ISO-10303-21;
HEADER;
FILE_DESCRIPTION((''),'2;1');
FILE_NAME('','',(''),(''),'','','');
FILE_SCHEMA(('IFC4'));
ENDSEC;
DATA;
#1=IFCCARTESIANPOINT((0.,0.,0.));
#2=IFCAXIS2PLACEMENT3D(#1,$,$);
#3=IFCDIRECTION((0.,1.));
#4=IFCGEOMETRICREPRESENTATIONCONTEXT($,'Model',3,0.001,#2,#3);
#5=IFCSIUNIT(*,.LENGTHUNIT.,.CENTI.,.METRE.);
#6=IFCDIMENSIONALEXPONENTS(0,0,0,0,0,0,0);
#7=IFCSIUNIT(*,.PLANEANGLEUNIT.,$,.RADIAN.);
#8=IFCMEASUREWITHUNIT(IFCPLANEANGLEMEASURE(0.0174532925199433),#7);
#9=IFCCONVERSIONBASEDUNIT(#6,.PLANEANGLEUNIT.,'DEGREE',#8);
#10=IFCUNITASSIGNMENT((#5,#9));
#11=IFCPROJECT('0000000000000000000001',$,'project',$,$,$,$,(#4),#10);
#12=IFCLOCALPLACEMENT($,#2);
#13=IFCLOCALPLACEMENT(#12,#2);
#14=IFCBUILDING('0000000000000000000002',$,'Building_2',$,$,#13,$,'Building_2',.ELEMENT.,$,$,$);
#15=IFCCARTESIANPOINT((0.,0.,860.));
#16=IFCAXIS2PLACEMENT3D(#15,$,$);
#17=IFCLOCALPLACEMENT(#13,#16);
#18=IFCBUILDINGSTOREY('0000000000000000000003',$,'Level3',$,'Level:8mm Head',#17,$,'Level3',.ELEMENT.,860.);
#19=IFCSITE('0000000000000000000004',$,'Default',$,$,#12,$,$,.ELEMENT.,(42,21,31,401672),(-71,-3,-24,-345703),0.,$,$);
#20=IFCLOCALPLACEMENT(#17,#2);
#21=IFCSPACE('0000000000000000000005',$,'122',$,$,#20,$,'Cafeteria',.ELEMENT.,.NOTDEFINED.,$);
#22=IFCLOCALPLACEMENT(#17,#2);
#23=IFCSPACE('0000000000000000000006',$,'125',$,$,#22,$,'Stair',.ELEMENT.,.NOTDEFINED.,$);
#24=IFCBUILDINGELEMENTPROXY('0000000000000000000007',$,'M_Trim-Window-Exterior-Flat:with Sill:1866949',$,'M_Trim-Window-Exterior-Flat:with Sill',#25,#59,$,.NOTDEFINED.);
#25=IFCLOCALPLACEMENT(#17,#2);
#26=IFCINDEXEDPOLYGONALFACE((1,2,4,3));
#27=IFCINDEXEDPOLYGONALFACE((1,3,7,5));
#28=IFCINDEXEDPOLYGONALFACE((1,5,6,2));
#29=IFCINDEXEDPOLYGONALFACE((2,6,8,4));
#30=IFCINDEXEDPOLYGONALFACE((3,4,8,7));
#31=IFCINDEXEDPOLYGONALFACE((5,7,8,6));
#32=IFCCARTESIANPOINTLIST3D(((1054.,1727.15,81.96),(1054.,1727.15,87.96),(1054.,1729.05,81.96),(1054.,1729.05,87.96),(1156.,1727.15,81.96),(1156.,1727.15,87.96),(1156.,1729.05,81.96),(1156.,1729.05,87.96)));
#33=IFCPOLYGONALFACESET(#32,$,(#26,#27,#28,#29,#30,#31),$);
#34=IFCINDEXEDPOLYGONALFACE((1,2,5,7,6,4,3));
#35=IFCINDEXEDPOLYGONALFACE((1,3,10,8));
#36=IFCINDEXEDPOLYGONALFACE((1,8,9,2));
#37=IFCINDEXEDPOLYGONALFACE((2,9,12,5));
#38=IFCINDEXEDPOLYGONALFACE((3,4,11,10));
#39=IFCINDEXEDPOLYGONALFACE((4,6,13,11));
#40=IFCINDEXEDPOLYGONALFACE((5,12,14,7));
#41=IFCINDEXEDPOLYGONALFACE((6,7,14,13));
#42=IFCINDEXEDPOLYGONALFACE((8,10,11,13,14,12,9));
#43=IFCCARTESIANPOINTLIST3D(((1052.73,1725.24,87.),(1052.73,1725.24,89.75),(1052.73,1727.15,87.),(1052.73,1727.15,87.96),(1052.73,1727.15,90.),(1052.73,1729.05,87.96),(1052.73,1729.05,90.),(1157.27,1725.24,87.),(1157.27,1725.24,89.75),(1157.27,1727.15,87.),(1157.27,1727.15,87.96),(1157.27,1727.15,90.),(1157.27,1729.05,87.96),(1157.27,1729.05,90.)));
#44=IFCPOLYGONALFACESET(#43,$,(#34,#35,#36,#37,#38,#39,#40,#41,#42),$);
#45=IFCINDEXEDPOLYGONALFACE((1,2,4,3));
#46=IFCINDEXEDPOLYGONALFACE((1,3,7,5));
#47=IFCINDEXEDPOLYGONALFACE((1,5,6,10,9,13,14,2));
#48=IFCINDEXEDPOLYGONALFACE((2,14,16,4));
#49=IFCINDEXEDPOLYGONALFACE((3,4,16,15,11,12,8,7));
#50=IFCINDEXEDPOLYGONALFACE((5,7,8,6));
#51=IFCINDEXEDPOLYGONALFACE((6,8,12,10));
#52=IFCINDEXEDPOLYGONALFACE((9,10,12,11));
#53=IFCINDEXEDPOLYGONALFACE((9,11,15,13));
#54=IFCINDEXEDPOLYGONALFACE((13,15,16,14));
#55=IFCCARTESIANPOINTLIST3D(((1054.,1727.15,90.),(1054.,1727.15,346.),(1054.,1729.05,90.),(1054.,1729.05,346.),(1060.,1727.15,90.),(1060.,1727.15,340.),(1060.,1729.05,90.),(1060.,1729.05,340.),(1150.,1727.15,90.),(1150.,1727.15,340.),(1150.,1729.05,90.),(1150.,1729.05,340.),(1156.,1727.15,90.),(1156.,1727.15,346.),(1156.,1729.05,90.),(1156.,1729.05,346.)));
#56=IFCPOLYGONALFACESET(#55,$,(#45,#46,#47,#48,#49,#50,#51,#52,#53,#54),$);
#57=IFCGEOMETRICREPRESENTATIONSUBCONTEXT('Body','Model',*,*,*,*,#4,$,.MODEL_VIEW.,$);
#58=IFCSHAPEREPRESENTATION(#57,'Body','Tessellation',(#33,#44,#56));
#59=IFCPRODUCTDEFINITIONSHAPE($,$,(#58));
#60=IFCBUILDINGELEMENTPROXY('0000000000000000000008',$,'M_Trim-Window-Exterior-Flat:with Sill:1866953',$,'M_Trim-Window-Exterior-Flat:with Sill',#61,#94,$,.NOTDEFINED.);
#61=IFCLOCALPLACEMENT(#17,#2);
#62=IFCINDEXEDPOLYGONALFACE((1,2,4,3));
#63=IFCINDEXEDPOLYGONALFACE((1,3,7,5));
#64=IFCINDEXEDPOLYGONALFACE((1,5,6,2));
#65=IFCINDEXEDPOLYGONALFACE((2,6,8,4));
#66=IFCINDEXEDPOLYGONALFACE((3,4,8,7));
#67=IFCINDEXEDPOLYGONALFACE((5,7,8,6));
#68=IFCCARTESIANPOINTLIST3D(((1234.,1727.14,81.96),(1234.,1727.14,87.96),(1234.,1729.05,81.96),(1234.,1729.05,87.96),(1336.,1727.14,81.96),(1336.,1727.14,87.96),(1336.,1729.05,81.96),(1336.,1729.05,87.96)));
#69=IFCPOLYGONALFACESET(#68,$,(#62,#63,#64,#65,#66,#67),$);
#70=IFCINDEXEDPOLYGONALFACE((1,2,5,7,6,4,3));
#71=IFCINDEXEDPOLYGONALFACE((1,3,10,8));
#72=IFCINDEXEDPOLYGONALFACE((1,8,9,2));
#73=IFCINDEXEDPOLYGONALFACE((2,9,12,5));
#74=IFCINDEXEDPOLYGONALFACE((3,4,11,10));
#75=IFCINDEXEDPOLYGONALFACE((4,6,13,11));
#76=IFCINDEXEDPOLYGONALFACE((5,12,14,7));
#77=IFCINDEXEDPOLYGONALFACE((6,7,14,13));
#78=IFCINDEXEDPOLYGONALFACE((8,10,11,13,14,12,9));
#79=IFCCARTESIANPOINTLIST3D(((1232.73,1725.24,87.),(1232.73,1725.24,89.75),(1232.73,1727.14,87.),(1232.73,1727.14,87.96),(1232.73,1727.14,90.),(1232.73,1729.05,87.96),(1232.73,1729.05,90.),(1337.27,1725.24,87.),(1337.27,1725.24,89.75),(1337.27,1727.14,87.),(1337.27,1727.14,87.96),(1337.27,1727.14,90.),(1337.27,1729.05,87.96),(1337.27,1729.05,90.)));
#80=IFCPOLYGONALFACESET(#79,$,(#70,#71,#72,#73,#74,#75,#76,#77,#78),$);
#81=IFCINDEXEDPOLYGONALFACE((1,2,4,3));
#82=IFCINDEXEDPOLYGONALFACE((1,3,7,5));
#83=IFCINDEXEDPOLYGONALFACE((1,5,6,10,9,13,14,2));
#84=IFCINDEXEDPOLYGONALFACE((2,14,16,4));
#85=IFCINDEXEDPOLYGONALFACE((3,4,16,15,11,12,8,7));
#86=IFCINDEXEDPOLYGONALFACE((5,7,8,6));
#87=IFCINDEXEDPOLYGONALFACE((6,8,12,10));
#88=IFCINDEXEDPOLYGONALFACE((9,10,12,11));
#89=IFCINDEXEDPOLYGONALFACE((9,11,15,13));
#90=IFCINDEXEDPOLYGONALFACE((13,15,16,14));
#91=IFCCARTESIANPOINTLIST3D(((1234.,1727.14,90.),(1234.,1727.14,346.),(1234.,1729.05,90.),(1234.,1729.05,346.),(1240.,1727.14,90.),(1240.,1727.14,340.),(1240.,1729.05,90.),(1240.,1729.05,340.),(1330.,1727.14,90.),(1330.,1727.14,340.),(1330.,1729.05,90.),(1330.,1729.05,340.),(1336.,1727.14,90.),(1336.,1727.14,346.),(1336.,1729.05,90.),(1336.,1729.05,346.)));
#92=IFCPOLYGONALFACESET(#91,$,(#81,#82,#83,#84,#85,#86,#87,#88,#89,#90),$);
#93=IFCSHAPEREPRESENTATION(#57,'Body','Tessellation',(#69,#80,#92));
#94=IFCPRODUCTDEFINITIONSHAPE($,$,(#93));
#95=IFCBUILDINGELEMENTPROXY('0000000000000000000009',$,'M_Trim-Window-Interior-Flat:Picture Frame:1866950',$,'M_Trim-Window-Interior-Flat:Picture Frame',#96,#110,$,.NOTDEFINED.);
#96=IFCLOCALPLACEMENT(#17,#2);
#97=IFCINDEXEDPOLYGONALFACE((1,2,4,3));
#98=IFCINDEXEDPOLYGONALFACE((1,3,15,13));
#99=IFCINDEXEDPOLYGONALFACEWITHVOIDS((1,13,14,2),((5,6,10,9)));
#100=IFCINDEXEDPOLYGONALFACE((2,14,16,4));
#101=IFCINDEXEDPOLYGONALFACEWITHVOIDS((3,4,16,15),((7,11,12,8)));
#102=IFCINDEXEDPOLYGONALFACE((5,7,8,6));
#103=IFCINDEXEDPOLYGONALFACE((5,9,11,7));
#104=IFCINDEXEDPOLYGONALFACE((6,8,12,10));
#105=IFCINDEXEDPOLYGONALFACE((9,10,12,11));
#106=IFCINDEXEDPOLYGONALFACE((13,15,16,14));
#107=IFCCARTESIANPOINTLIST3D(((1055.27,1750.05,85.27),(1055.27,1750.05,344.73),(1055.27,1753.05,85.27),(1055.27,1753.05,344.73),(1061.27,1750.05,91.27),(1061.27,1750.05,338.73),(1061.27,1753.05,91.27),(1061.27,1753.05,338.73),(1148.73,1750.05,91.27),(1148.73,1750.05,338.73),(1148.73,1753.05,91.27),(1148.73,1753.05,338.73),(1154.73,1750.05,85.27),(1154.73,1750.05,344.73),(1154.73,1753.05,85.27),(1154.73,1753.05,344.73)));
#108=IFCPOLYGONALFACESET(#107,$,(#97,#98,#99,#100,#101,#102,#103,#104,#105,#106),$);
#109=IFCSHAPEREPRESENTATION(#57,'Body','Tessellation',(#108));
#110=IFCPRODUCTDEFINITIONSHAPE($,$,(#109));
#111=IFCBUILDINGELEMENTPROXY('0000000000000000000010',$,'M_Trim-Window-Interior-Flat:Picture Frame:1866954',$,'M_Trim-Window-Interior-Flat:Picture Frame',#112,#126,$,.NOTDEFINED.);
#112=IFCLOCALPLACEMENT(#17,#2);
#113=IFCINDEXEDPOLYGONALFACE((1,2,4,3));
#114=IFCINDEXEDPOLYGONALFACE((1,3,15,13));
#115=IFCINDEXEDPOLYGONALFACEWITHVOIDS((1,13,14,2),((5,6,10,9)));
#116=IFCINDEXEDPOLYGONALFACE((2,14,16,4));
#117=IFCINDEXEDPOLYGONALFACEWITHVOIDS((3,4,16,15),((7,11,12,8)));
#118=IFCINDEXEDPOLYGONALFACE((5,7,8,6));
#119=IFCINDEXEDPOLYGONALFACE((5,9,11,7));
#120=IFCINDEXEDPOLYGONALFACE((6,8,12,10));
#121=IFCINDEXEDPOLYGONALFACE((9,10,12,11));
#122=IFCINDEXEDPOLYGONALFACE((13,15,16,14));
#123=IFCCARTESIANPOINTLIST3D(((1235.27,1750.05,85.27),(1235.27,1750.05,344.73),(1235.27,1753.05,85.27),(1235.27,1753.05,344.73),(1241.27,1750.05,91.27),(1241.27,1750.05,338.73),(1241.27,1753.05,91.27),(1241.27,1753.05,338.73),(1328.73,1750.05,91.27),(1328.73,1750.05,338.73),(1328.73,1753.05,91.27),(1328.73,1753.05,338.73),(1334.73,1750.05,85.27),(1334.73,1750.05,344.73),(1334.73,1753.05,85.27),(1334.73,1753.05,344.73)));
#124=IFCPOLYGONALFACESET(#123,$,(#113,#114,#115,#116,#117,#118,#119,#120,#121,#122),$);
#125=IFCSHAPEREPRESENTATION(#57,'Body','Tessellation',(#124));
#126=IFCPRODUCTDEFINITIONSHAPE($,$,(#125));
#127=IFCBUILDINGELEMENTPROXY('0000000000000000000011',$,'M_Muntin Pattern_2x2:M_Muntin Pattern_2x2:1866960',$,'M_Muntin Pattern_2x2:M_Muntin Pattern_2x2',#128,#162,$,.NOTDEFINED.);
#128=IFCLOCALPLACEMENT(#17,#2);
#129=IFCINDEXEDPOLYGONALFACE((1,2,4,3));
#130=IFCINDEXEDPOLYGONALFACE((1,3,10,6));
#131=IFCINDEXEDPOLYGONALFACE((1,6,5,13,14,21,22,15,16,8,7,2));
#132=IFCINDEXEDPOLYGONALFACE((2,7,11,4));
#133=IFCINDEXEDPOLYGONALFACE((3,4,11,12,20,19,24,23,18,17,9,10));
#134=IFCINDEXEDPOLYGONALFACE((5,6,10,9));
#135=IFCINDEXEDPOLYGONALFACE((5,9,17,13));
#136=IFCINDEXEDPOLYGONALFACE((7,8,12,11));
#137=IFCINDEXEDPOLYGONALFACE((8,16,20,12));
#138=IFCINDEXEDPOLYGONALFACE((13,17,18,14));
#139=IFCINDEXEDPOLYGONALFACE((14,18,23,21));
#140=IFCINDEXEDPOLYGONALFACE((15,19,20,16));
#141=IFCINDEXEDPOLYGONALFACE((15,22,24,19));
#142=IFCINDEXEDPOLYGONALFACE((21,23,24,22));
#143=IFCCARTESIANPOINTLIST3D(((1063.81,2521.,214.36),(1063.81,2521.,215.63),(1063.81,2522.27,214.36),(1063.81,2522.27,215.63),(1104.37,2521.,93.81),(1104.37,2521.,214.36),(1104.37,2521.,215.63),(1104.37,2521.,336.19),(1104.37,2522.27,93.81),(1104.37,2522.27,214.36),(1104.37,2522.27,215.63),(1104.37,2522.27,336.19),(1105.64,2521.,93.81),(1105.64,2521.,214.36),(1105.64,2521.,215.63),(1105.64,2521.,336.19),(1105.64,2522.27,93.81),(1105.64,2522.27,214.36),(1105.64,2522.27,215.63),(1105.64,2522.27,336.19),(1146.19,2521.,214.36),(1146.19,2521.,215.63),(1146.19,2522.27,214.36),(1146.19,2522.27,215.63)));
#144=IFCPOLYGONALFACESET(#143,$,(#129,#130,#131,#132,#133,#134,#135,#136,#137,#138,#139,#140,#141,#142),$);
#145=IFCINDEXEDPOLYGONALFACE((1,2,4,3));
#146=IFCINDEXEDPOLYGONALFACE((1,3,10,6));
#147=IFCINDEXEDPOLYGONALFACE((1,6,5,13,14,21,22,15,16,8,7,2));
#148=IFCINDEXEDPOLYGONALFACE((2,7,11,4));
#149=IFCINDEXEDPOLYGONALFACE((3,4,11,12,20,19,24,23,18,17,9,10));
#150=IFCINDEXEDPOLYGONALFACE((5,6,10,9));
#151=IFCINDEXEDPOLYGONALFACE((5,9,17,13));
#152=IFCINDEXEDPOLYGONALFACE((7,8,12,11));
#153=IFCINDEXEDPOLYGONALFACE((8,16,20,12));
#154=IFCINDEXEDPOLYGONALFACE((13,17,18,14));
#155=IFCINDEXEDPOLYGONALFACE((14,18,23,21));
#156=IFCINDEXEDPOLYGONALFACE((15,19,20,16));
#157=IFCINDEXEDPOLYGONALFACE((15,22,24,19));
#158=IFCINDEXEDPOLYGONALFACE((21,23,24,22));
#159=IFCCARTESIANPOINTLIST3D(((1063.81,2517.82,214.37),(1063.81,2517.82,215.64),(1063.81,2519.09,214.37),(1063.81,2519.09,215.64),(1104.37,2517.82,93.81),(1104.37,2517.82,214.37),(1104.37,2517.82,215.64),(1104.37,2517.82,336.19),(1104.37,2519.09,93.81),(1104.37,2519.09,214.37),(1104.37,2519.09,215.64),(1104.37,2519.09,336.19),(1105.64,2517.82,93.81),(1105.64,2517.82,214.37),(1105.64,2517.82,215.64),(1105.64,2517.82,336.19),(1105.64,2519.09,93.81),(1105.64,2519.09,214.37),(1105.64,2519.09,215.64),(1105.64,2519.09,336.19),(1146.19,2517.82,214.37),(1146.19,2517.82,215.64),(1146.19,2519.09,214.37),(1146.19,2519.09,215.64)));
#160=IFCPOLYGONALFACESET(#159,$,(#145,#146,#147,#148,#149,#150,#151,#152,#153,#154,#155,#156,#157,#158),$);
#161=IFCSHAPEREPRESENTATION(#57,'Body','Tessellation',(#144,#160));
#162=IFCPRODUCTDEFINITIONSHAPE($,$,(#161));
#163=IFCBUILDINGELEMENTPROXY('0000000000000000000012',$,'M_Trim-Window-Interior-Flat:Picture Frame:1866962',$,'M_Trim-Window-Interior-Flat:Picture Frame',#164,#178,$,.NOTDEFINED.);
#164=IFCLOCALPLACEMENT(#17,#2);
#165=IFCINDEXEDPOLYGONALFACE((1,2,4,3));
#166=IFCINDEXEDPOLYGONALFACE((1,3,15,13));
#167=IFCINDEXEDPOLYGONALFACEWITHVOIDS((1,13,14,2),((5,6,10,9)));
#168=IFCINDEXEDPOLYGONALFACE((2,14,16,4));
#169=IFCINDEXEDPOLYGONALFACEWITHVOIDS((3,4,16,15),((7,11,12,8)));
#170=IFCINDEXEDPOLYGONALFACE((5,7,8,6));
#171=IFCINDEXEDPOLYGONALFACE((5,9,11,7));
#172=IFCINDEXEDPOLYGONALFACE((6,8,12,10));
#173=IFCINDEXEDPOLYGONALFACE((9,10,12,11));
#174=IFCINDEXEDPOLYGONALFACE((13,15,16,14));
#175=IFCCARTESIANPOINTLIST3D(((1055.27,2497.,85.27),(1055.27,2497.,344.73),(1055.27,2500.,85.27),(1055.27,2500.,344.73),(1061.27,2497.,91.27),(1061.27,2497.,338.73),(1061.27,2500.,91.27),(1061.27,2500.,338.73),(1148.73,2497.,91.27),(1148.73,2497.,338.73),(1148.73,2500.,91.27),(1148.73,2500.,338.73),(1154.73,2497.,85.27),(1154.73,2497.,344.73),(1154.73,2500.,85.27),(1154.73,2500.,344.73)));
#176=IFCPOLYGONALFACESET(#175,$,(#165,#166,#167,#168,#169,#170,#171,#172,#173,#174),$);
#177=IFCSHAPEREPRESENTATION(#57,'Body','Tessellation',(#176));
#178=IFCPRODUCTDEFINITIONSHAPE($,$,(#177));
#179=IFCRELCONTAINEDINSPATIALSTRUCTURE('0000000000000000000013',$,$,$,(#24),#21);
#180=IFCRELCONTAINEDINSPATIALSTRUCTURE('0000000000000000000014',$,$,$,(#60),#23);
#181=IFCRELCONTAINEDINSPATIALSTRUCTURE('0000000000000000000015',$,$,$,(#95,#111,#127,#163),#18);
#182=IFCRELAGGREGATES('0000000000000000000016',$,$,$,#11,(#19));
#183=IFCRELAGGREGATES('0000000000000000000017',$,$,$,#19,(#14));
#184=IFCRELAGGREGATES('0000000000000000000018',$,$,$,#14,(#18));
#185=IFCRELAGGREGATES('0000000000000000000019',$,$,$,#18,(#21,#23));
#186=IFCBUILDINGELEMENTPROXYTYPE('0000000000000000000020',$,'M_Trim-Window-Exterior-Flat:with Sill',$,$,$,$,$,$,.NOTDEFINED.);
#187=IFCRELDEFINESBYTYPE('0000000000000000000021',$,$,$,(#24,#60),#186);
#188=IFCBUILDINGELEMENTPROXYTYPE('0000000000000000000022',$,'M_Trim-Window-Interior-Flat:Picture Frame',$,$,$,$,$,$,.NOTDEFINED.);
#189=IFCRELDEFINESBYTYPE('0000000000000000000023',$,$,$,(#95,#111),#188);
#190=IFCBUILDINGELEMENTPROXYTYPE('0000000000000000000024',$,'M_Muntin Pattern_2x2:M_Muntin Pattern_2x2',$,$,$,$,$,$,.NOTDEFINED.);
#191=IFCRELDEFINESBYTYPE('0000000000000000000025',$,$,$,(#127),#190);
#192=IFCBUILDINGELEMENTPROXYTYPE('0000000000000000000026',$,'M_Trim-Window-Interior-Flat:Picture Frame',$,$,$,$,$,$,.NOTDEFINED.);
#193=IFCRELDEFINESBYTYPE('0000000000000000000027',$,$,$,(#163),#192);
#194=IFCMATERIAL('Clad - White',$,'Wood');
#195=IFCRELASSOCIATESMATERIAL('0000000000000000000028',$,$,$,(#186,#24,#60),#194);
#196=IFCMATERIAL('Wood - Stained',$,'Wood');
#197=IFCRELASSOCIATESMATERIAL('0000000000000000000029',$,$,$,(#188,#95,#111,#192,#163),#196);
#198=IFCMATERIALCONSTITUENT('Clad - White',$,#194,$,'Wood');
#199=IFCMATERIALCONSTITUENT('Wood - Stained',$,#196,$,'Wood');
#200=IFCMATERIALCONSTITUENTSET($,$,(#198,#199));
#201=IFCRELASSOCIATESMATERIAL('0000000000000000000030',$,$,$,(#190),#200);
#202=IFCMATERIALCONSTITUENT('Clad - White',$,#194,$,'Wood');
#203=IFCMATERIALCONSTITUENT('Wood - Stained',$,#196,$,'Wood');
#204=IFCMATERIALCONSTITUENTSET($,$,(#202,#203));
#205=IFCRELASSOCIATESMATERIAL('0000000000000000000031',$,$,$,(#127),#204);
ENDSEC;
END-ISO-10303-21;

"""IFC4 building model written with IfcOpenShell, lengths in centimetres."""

from ifc_helpers import new_model, entity, si_unit, converted_unit, direction, frame, origin, place, context, subcontext, project, spatial, indexed_curve, outline, extrude, source, transform, mapped, material, constituent, constituent_set, type_object, type_shapes, element, save


model = new_model("IFC4")

# Units and contexts
model_context = context("Model", 3, precision=0.001, world=origin(), true_north=direction((0.0, 1.0)))
body_context = subcontext(model_context, "Body", "Model", "MODEL_VIEW")
ifc_project = project(units=[si_unit("LENGTHUNIT", "METRE", prefix="CENTI"), converted_unit("PLANEANGLEUNIT", "DEGREE", entity("IfcPlaneAngleMeasure", 0.0174532925199433), si_unit("PLANEANGLEUNIT", "RADIAN"), dimensions=[0, 0, 0, 0, 0, 0, 0])], contexts=[model_context])

# Site, building, storey
site_placement = place(None, origin())
site = spatial("IfcSite", under=ifc_project, at=site_placement, Name="Default", CompositionType="ELEMENT", RefLatitude=(42, 21, 31, 401672), RefLongitude=(-71, -3, -24, -345703), RefElevation=0.0)
building_placement = place(site_placement, origin())
building = spatial("IfcBuilding", under=site, at=building_placement, Name="Building_2", LongName="Building_2", CompositionType="ELEMENT")
storey_placement = place(building_placement, frame((0.0, 0.0, 860.0)))
storey = spatial("IfcBuildingStorey", under=building, at=storey_placement, Name="Level3", ObjectType="Level:8mm Head", LongName="Level3", CompositionType="ELEMENT", Elevation=860.0)

# Shared definitions
ifc_material_1 = material(Name="Clad - White", Category="Wood")
ifc_material_2 = material(Name="Wood - Stained", Category="Wood")

# Shared definitions
space_1_placement = place(storey_placement, origin())
space_1 = spatial("IfcSpace", under=storey, at=space_1_placement, Name="122", LongName="Cafeteria", CompositionType="ELEMENT", PredefinedType="NOTDEFINED")

# Building element proxy
building_element_proxy_type_1 = type_object("IfcBuildingElementProxyType", Name="M_Trim-Window-Exterior-Flat:with Sill", PredefinedType="NOTDEFINED", material=ifc_material_1)
shared_shape_1 = source(origin(), body_context, "Body", "SweptSolid", [
    extrude(outline(indexed_curve([(-3.0, -51.0), (3.0, -51.0), (3.0, 51.0), (-3.0, 51.0), (-3.0, -51.0)], self_intersect=False)), frame((0.0, 255.04, 0.0), z_axis=(0.0, 0.0, 1.0), x_axis=(0.0, 1.0, 0.0)), (0.0, 0.0, 1.0), 1.91),
    extrude(outline(indexed_curve([(-1.52, -1.9), (1.23, -1.9), (1.48, 0.0), (1.48, 1.9), (-0.57, 1.9), (-0.57, 0.0), (-1.52, 0.0), (-1.52, -1.9)], self_intersect=False)), frame((-52.27, 251.48, 1.9), z_axis=(1.0, 0.0, 0.0), x_axis=(0.0, -1.0, 0.0)), (0.0, 0.0, 1.0), 104.54),
    extrude(outline(indexed_curve([(-51.0, -129.5), (51.0, -129.5), (51.0, 126.5), (45.0, 126.5), (45.0, -123.5), (-45.0, -123.5), (-45.0, 126.5), (-51.0, 126.5), (-51.0, -129.5)], self_intersect=False)), frame((0.0, 123.5, 0.0)), (0.0, 0.0, 1.0), 1.91),
])
type_shapes(building_element_proxy_type_1, [shared_shape_1])
proxy_1_placement = place(space_1_placement, frame((1105.0, 1729.05, 340.0), z_axis=(0.0, -1.0, 0.0), x_axis=(-1.0, 0.0, 0.0)))
element("IfcBuildingElementProxy", 1, at=proxy_1_placement, inside=space_1, type_object=building_element_proxy_type_1, material=ifc_material_1, Name="M_Trim-Window-Exterior-Flat:with Sill:1866949", ObjectType="M_Trim-Window-Exterior-Flat:with Sill", PredefinedType="NOTDEFINED", context=body_context, shape_type="MappedRepresentation", body=[
    mapped(shared_shape_1, transform((0.0, 0.0, 0.0), scale=1.0)),
])

# Shared definitions
space_2_placement = place(storey_placement, origin())
space_2 = spatial("IfcSpace", under=storey, at=space_2_placement, Name="125", LongName="Stair", CompositionType="ELEMENT", PredefinedType="NOTDEFINED")

# Building element proxies
proxy_2_placement = place(space_2_placement, frame((1285.0, 1729.05, 340.0), z_axis=(0.0, -1.0, 0.0), x_axis=(-1.0, 0.0, 0.0)))
element("IfcBuildingElementProxy", 2, at=proxy_2_placement, inside=space_2, type_object=building_element_proxy_type_1, material=ifc_material_1, Name="M_Trim-Window-Exterior-Flat:with Sill:1866953", ObjectType="M_Trim-Window-Exterior-Flat:with Sill", PredefinedType="NOTDEFINED", context=body_context, shape_type="MappedRepresentation", body=[
    mapped(shared_shape_1, transform((0.0, 0.0, 0.0), scale=1.0)),
])
building_element_proxy_type_2 = type_object("IfcBuildingElementProxyType", Name="M_Trim-Window-Interior-Flat:Picture Frame", PredefinedType="NOTDEFINED", material=ifc_material_2)
shared_shape_2 = source(origin(), body_context, "Body", "SweptSolid", [
    extrude(outline(indexed_curve([(-129.73, -49.73), (129.73, -49.73), (129.73, 49.73), (-129.73, 49.73), (-129.73, -49.73)], self_intersect=False), holes=[indexed_curve([(-123.73, -43.73), (-123.73, 43.73), (123.73, 43.73), (123.73, -43.73), (-123.73, -43.73)], self_intersect=False)]), frame((0.0, 125.0, 0.0), z_axis=(0.0, 0.0, 1.0), x_axis=(0.0, 1.0, 0.0)), (0.0, 0.0, 1.0), 3.0),
])
type_shapes(building_element_proxy_type_2, [shared_shape_2])
for number, where, z_axis, x_axis, name in (
    (3, (1105.0, 1750.05, 340.0), (0.0, 1.0, 0.0), (1.0, 0.0, 0.0), "M_Trim-Window-Interior-Flat:Picture Frame:1866950"),
    (4, (1285.0, 1750.05, 340.0), (0.0, 1.0, 0.0), (1.0, 0.0, 0.0), "M_Trim-Window-Interior-Flat:Picture Frame:1866954"),
):
    element("IfcBuildingElementProxy", number, at=place(storey_placement, frame(where, z_axis=z_axis, x_axis=x_axis)), inside=storey, type_object=building_element_proxy_type_2, material=ifc_material_2, Name=name, ObjectType="M_Trim-Window-Interior-Flat:Picture Frame", PredefinedType="NOTDEFINED", context=body_context, shape_type="MappedRepresentation", body=[
        mapped(shared_shape_2, transform((0.0, 0.0, 0.0), scale=1.0)),
    ])
ifc_constituent_1 = constituent(ifc_material_1, Name="Clad - White", Category="Wood")
ifc_constituent_2 = constituent(ifc_material_2, Name="Wood - Stained", Category="Wood")
ifc_constituent_set_1 = constituent_set(constituents=[ifc_constituent_1, ifc_constituent_2])
ifc_constituent_3 = constituent(ifc_material_1, Name="Clad - White", Category="Wood")
ifc_constituent_4 = constituent(ifc_material_2, Name="Wood - Stained", Category="Wood")
ifc_constituent_set_2 = constituent_set(constituents=[ifc_constituent_3, ifc_constituent_4])
building_element_proxy_type_3 = type_object("IfcBuildingElementProxyType", Name="M_Muntin Pattern_2x2:M_Muntin Pattern_2x2", PredefinedType="NOTDEFINED", material=ifc_constituent_set_2)
shared_shape_3 = source(origin(), body_context, "Body", "SweptSolid", [
    extrude(outline(indexed_curve([(0.64, -0.64), (121.19, -0.64), (121.19, 0.63), (0.64, 0.63), (0.64, 41.19), (-0.63, 41.19), (-0.63, 0.63), (-121.19, 0.63), (-121.19, -0.64), (-0.63, -0.64), (-0.63, -41.19), (0.64, -41.19), (0.64, -0.64)], self_intersect=False)), frame((0.0, -2.22, 121.19), z_axis=(0.0, 1.0, 0.0), x_axis=(0.0, 0.0, 1.0)), (0.0, 0.0, 1.0), 1.27),
    extrude(outline(indexed_curve([(0.64, -0.64), (121.19, -0.64), (121.19, 0.63), (0.64, 0.63), (0.64, 41.19), (-0.63, 41.19), (-0.63, 0.63), (-121.19, 0.63), (-121.19, -0.64), (-0.63, -0.64), (-0.63, -41.19), (0.64, -41.19), (0.64, -0.64)], self_intersect=False)), frame((0.0, 0.95, 121.19), z_axis=(0.0, 1.0, 0.0), x_axis=(0.0, 0.0, 1.0)), (0.0, 0.0, 1.0), 1.27),
])
type_shapes(building_element_proxy_type_3, [shared_shape_3])
proxy_3_placement = place(storey_placement, frame((1105.0, 2520.05, 93.81), z_axis=(0.0, 0.0, 1.0), x_axis=(-1.0, 0.0, 0.0)))
element("IfcBuildingElementProxy", 5, at=proxy_3_placement, inside=storey, type_object=building_element_proxy_type_3, material=ifc_constituent_set_1, Name="M_Muntin Pattern_2x2:M_Muntin Pattern_2x2:1866960", ObjectType="M_Muntin Pattern_2x2:M_Muntin Pattern_2x2", PredefinedType="NOTDEFINED", context=body_context, shape_type="MappedRepresentation", body=[
    mapped(shared_shape_3, transform((0.0, 0.0, 0.0), scale=1.0)),
])
building_element_proxy_type_4 = type_object("IfcBuildingElementProxyType", Name="M_Trim-Window-Interior-Flat:Picture Frame", PredefinedType="NOTDEFINED", material=ifc_material_2)
shared_shape_4 = source(origin(), body_context, "Body", "SweptSolid", [
    extrude(outline(indexed_curve([(-49.73, -129.73), (49.73, -129.73), (49.73, 129.73), (-49.73, 129.73), (-49.73, -129.73)], self_intersect=False), holes=[indexed_curve([(-43.73, -123.73), (-43.73, 123.73), (43.73, 123.73), (43.73, -123.73), (-43.73, -123.73)], self_intersect=False)]), frame((0.0, -125.0, 0.0), z_axis=(0.0, 0.0, 1.0), x_axis=(-1.0, 0.0, 0.0)), (0.0, 0.0, 1.0), 3.0),
])
type_shapes(building_element_proxy_type_4, [shared_shape_4])
for number, where, z_axis, x_axis, name in (
    (6, (1105.0, 2500.0, 340.0), (0.0, -1.0, 0.0), (1.0, 0.0, 0.0), "M_Trim-Window-Interior-Flat:Picture Frame:1866962"),
):
    element("IfcBuildingElementProxy", number, at=place(storey_placement, frame(where, z_axis=z_axis, x_axis=x_axis)), inside=storey, type_object=building_element_proxy_type_4, material=ifc_material_2, Name=name, ObjectType="M_Trim-Window-Interior-Flat:Picture Frame", PredefinedType="NOTDEFINED", context=body_context, shape_type="MappedRepresentation", body=[
        mapped(shared_shape_4, transform((0.0, 0.0, 0.0), scale=1.0)),
    ])

save(model, "model.ifc")
